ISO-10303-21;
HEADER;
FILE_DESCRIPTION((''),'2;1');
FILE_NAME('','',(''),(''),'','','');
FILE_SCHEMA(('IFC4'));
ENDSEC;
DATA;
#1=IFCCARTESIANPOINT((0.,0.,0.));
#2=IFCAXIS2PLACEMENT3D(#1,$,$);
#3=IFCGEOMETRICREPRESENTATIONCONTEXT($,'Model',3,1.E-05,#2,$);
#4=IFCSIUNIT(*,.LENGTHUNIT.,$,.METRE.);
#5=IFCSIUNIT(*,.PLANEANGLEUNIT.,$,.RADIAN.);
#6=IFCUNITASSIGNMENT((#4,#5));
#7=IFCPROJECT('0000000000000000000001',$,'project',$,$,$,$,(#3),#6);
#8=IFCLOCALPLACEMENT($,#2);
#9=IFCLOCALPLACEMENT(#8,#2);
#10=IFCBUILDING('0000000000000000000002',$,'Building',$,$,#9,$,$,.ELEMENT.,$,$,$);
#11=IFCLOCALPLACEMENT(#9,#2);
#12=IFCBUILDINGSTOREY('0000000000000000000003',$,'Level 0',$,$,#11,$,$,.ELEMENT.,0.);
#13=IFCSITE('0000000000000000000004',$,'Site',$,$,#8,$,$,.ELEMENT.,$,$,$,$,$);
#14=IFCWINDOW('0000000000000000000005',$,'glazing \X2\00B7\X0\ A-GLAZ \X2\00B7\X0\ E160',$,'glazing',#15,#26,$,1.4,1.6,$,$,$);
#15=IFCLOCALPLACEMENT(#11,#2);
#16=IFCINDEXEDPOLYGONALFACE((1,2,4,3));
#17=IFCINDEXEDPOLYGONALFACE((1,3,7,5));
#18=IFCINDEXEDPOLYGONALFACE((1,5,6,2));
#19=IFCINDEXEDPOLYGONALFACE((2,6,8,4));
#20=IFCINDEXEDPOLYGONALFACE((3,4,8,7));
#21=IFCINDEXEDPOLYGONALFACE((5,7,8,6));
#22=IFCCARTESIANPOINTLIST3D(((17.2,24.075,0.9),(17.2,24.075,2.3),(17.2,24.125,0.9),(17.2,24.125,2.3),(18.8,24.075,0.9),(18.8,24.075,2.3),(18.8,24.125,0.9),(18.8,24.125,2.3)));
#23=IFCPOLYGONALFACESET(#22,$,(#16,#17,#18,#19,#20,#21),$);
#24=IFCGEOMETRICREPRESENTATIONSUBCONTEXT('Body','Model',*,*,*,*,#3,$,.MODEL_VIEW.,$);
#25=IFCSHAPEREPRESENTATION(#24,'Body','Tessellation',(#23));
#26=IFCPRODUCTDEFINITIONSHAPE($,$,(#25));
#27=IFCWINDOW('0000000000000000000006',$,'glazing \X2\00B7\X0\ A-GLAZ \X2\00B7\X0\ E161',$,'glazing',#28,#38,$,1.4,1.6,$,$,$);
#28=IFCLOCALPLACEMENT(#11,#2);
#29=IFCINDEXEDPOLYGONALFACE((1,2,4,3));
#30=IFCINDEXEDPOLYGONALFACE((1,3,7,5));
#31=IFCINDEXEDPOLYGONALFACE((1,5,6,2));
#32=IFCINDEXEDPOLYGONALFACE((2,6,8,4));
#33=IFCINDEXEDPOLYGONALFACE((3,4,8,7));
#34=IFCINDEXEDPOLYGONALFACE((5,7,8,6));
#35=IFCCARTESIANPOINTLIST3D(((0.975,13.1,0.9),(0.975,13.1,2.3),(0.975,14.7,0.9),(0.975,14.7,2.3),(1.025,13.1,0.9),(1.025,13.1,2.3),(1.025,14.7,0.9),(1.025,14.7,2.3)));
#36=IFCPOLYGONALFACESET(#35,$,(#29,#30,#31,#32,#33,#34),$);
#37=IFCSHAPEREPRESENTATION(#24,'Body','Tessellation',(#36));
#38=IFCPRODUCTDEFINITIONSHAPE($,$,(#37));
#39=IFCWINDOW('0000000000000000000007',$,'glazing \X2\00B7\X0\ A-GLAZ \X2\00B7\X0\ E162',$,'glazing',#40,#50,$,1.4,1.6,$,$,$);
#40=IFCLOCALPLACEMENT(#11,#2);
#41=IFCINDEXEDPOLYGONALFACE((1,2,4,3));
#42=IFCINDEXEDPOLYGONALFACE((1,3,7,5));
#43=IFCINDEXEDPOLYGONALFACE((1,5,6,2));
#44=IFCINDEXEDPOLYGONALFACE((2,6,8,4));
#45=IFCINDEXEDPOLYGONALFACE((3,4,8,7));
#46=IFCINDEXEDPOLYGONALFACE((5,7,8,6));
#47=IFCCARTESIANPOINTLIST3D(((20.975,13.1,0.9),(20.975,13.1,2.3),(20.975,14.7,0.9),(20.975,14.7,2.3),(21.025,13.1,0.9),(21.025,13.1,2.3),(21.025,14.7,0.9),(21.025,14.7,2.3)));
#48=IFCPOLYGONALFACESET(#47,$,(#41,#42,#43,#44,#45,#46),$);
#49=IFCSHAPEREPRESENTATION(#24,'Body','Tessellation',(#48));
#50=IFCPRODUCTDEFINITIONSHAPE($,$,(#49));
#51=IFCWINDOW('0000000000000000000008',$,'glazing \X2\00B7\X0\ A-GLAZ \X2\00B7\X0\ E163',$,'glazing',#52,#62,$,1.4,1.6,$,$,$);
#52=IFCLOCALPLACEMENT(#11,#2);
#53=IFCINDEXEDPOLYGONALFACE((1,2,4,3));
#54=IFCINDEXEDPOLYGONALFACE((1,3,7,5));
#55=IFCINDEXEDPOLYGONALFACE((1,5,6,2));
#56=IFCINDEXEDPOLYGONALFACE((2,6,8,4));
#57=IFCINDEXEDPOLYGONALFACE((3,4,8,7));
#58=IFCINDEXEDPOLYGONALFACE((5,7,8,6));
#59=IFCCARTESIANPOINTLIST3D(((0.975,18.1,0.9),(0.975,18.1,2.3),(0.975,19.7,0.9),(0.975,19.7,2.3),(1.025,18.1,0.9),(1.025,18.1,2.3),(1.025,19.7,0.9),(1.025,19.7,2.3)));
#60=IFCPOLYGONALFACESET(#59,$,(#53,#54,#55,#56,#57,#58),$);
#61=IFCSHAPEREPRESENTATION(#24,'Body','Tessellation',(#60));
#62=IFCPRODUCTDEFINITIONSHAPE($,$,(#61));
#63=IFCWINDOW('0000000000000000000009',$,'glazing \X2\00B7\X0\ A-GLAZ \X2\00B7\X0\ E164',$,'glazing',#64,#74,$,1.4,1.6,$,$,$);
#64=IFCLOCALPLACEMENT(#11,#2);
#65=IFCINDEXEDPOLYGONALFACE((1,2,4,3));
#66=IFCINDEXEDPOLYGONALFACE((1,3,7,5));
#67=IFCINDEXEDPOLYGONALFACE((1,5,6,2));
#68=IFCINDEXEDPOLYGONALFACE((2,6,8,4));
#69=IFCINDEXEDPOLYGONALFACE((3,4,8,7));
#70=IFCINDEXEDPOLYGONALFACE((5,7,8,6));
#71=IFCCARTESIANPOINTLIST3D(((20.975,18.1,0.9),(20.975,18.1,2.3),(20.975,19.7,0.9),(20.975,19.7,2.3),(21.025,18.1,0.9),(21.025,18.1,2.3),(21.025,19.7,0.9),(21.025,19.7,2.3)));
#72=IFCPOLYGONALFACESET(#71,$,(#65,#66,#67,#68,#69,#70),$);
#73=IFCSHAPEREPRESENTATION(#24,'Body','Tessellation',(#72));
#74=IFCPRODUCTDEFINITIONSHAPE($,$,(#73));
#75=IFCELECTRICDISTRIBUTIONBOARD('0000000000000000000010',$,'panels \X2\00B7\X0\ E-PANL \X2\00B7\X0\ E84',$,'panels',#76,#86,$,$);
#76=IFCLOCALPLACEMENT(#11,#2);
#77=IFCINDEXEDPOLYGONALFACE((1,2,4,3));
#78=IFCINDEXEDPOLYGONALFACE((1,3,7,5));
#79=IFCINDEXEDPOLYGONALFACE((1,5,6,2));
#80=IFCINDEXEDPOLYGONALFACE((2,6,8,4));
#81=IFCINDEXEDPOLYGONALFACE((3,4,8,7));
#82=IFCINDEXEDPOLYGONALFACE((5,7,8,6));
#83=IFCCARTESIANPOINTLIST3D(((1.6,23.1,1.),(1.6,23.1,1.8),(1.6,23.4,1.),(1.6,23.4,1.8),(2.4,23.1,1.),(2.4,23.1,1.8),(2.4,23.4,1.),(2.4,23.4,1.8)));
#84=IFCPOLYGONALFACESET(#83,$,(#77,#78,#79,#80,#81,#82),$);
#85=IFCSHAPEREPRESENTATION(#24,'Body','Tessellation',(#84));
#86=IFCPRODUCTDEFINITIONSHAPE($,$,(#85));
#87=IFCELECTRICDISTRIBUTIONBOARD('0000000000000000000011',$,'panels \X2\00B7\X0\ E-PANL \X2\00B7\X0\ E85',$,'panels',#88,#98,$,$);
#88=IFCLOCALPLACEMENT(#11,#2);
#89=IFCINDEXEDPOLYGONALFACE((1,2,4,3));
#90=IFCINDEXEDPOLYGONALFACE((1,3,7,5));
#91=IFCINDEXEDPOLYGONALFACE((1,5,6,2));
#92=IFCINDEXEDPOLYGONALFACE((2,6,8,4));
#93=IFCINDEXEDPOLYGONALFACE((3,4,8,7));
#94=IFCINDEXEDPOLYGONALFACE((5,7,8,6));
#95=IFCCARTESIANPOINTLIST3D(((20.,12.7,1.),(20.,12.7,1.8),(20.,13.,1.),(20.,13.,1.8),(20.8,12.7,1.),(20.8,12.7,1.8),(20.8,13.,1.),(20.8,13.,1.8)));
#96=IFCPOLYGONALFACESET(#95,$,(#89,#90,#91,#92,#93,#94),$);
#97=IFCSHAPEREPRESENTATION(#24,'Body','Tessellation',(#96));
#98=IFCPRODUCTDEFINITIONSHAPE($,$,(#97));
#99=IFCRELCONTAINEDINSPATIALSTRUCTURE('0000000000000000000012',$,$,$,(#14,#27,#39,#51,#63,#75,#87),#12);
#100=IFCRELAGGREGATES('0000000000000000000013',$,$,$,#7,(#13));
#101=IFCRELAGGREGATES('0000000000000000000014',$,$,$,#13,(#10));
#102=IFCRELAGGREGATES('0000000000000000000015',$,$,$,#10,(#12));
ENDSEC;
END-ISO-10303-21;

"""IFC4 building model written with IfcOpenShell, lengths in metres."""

from ifc_helpers import new_model, si_unit, frame, origin, place, context, subcontext, project, spatial, polyline, outline, extrude, element, save


model = new_model("IFC4")

# Units and contexts
model_context = context("Model", 3, precision=1e-05, world=origin())
body_context = subcontext(model_context, "Body", "Model", "MODEL_VIEW")
ifc_project = project(units=[si_unit("LENGTHUNIT", "METRE"), si_unit("PLANEANGLEUNIT", "RADIAN")], contexts=[model_context])

# Site, building, storey
site_placement = place(None, origin())
site = spatial("IfcSite", under=ifc_project, at=site_placement, Name="Site", CompositionType="ELEMENT")
building_placement = place(site_placement, origin())
building = spatial("IfcBuilding", under=site, at=building_placement, Name="Building", CompositionType="ELEMENT")
storey_placement = place(building_placement, origin())
storey = spatial("IfcBuildingStorey", under=building, at=storey_placement, Name="Level 0", CompositionType="ELEMENT", Elevation=0.0)

# Windows
window_1_placement = place(storey_placement, frame((0.0, 0.0, 0.9)))
element("IfcWindow", 1, at=window_1_placement, inside=storey, Name="glazing · A-GLAZ · E160", ObjectType="glazing", OverallHeight=1.4, OverallWidth=1.6, context=body_context, shape_type="SweptSolid", body=[
    extrude(outline(polyline([(18.8, 24.125), (17.2, 24.125), (17.2, 24.075), (18.8, 24.075), (18.8, 24.125)])), origin(), (0.0, 0.0, 1.0), 1.4),
])
window_2_placement = place(storey_placement, frame((0.0, 0.0, 0.9)))
element("IfcWindow", 2, at=window_2_placement, inside=storey, Name="glazing · A-GLAZ · E161", ObjectType="glazing", OverallHeight=1.4, OverallWidth=1.6, context=body_context, shape_type="SweptSolid", body=[
    extrude(outline(polyline([(0.975, 14.7), (0.975, 13.1), (1.025, 13.1), (1.025, 14.7), (0.975, 14.7)])), origin(), (0.0, 0.0, 1.0), 1.4),
])
window_3_placement = place(storey_placement, frame((0.0, 0.0, 0.9)))
element("IfcWindow", 3, at=window_3_placement, inside=storey, Name="glazing · A-GLAZ · E162", ObjectType="glazing", OverallHeight=1.4, OverallWidth=1.6, context=body_context, shape_type="SweptSolid", body=[
    extrude(outline(polyline([(21.025, 13.1), (21.025, 14.7), (20.975, 14.7), (20.975, 13.1), (21.025, 13.1)])), origin(), (0.0, 0.0, 1.0), 1.4),
])
window_4_placement = place(storey_placement, frame((0.0, 0.0, 0.9)))
element("IfcWindow", 4, at=window_4_placement, inside=storey, Name="glazing · A-GLAZ · E163", ObjectType="glazing", OverallHeight=1.4, OverallWidth=1.6, context=body_context, shape_type="SweptSolid", body=[
    extrude(outline(polyline([(0.975, 19.7), (0.975, 18.1), (1.025, 18.1), (1.025, 19.7), (0.975, 19.7)])), origin(), (0.0, 0.0, 1.0), 1.4),
])
window_5_placement = place(storey_placement, frame((0.0, 0.0, 0.9)))
element("IfcWindow", 5, at=window_5_placement, inside=storey, Name="glazing · A-GLAZ · E164", ObjectType="glazing", OverallHeight=1.4, OverallWidth=1.6, context=body_context, shape_type="SweptSolid", body=[
    extrude(outline(polyline([(21.025, 18.1), (21.025, 19.7), (20.975, 19.7), (20.975, 18.1), (21.025, 18.1)])), origin(), (0.0, 0.0, 1.0), 1.4),
])

# Electric distribution boards
electric_distribution_board_1_placement = place(storey_placement, frame((0.0, 0.0, 1.0)))
element("IfcElectricDistributionBoard", 6, at=electric_distribution_board_1_placement, inside=storey, Name="panels · E-PANL · E84", ObjectType="panels", context=body_context, shape_type="SweptSolid", body=[
    extrude(outline(polyline([(1.6, 23.1), (2.4, 23.1), (2.4, 23.4), (1.6, 23.4), (1.6, 23.1)])), origin(), (0.0, 0.0, 1.0), 0.8),
])
electric_distribution_board_2_placement = place(storey_placement, frame((0.0, 0.0, 1.0)))
element("IfcElectricDistributionBoard", 7, at=electric_distribution_board_2_placement, inside=storey, Name="panels · E-PANL · E85", ObjectType="panels", context=body_context, shape_type="SweptSolid", body=[
    extrude(outline(polyline([(20.0, 12.7), (20.8, 12.7), (20.8, 13.0), (20.0, 13.0), (20.0, 12.7)])), origin(), (0.0, 0.0, 1.0), 0.8),
])

save(model, "model.ifc")
